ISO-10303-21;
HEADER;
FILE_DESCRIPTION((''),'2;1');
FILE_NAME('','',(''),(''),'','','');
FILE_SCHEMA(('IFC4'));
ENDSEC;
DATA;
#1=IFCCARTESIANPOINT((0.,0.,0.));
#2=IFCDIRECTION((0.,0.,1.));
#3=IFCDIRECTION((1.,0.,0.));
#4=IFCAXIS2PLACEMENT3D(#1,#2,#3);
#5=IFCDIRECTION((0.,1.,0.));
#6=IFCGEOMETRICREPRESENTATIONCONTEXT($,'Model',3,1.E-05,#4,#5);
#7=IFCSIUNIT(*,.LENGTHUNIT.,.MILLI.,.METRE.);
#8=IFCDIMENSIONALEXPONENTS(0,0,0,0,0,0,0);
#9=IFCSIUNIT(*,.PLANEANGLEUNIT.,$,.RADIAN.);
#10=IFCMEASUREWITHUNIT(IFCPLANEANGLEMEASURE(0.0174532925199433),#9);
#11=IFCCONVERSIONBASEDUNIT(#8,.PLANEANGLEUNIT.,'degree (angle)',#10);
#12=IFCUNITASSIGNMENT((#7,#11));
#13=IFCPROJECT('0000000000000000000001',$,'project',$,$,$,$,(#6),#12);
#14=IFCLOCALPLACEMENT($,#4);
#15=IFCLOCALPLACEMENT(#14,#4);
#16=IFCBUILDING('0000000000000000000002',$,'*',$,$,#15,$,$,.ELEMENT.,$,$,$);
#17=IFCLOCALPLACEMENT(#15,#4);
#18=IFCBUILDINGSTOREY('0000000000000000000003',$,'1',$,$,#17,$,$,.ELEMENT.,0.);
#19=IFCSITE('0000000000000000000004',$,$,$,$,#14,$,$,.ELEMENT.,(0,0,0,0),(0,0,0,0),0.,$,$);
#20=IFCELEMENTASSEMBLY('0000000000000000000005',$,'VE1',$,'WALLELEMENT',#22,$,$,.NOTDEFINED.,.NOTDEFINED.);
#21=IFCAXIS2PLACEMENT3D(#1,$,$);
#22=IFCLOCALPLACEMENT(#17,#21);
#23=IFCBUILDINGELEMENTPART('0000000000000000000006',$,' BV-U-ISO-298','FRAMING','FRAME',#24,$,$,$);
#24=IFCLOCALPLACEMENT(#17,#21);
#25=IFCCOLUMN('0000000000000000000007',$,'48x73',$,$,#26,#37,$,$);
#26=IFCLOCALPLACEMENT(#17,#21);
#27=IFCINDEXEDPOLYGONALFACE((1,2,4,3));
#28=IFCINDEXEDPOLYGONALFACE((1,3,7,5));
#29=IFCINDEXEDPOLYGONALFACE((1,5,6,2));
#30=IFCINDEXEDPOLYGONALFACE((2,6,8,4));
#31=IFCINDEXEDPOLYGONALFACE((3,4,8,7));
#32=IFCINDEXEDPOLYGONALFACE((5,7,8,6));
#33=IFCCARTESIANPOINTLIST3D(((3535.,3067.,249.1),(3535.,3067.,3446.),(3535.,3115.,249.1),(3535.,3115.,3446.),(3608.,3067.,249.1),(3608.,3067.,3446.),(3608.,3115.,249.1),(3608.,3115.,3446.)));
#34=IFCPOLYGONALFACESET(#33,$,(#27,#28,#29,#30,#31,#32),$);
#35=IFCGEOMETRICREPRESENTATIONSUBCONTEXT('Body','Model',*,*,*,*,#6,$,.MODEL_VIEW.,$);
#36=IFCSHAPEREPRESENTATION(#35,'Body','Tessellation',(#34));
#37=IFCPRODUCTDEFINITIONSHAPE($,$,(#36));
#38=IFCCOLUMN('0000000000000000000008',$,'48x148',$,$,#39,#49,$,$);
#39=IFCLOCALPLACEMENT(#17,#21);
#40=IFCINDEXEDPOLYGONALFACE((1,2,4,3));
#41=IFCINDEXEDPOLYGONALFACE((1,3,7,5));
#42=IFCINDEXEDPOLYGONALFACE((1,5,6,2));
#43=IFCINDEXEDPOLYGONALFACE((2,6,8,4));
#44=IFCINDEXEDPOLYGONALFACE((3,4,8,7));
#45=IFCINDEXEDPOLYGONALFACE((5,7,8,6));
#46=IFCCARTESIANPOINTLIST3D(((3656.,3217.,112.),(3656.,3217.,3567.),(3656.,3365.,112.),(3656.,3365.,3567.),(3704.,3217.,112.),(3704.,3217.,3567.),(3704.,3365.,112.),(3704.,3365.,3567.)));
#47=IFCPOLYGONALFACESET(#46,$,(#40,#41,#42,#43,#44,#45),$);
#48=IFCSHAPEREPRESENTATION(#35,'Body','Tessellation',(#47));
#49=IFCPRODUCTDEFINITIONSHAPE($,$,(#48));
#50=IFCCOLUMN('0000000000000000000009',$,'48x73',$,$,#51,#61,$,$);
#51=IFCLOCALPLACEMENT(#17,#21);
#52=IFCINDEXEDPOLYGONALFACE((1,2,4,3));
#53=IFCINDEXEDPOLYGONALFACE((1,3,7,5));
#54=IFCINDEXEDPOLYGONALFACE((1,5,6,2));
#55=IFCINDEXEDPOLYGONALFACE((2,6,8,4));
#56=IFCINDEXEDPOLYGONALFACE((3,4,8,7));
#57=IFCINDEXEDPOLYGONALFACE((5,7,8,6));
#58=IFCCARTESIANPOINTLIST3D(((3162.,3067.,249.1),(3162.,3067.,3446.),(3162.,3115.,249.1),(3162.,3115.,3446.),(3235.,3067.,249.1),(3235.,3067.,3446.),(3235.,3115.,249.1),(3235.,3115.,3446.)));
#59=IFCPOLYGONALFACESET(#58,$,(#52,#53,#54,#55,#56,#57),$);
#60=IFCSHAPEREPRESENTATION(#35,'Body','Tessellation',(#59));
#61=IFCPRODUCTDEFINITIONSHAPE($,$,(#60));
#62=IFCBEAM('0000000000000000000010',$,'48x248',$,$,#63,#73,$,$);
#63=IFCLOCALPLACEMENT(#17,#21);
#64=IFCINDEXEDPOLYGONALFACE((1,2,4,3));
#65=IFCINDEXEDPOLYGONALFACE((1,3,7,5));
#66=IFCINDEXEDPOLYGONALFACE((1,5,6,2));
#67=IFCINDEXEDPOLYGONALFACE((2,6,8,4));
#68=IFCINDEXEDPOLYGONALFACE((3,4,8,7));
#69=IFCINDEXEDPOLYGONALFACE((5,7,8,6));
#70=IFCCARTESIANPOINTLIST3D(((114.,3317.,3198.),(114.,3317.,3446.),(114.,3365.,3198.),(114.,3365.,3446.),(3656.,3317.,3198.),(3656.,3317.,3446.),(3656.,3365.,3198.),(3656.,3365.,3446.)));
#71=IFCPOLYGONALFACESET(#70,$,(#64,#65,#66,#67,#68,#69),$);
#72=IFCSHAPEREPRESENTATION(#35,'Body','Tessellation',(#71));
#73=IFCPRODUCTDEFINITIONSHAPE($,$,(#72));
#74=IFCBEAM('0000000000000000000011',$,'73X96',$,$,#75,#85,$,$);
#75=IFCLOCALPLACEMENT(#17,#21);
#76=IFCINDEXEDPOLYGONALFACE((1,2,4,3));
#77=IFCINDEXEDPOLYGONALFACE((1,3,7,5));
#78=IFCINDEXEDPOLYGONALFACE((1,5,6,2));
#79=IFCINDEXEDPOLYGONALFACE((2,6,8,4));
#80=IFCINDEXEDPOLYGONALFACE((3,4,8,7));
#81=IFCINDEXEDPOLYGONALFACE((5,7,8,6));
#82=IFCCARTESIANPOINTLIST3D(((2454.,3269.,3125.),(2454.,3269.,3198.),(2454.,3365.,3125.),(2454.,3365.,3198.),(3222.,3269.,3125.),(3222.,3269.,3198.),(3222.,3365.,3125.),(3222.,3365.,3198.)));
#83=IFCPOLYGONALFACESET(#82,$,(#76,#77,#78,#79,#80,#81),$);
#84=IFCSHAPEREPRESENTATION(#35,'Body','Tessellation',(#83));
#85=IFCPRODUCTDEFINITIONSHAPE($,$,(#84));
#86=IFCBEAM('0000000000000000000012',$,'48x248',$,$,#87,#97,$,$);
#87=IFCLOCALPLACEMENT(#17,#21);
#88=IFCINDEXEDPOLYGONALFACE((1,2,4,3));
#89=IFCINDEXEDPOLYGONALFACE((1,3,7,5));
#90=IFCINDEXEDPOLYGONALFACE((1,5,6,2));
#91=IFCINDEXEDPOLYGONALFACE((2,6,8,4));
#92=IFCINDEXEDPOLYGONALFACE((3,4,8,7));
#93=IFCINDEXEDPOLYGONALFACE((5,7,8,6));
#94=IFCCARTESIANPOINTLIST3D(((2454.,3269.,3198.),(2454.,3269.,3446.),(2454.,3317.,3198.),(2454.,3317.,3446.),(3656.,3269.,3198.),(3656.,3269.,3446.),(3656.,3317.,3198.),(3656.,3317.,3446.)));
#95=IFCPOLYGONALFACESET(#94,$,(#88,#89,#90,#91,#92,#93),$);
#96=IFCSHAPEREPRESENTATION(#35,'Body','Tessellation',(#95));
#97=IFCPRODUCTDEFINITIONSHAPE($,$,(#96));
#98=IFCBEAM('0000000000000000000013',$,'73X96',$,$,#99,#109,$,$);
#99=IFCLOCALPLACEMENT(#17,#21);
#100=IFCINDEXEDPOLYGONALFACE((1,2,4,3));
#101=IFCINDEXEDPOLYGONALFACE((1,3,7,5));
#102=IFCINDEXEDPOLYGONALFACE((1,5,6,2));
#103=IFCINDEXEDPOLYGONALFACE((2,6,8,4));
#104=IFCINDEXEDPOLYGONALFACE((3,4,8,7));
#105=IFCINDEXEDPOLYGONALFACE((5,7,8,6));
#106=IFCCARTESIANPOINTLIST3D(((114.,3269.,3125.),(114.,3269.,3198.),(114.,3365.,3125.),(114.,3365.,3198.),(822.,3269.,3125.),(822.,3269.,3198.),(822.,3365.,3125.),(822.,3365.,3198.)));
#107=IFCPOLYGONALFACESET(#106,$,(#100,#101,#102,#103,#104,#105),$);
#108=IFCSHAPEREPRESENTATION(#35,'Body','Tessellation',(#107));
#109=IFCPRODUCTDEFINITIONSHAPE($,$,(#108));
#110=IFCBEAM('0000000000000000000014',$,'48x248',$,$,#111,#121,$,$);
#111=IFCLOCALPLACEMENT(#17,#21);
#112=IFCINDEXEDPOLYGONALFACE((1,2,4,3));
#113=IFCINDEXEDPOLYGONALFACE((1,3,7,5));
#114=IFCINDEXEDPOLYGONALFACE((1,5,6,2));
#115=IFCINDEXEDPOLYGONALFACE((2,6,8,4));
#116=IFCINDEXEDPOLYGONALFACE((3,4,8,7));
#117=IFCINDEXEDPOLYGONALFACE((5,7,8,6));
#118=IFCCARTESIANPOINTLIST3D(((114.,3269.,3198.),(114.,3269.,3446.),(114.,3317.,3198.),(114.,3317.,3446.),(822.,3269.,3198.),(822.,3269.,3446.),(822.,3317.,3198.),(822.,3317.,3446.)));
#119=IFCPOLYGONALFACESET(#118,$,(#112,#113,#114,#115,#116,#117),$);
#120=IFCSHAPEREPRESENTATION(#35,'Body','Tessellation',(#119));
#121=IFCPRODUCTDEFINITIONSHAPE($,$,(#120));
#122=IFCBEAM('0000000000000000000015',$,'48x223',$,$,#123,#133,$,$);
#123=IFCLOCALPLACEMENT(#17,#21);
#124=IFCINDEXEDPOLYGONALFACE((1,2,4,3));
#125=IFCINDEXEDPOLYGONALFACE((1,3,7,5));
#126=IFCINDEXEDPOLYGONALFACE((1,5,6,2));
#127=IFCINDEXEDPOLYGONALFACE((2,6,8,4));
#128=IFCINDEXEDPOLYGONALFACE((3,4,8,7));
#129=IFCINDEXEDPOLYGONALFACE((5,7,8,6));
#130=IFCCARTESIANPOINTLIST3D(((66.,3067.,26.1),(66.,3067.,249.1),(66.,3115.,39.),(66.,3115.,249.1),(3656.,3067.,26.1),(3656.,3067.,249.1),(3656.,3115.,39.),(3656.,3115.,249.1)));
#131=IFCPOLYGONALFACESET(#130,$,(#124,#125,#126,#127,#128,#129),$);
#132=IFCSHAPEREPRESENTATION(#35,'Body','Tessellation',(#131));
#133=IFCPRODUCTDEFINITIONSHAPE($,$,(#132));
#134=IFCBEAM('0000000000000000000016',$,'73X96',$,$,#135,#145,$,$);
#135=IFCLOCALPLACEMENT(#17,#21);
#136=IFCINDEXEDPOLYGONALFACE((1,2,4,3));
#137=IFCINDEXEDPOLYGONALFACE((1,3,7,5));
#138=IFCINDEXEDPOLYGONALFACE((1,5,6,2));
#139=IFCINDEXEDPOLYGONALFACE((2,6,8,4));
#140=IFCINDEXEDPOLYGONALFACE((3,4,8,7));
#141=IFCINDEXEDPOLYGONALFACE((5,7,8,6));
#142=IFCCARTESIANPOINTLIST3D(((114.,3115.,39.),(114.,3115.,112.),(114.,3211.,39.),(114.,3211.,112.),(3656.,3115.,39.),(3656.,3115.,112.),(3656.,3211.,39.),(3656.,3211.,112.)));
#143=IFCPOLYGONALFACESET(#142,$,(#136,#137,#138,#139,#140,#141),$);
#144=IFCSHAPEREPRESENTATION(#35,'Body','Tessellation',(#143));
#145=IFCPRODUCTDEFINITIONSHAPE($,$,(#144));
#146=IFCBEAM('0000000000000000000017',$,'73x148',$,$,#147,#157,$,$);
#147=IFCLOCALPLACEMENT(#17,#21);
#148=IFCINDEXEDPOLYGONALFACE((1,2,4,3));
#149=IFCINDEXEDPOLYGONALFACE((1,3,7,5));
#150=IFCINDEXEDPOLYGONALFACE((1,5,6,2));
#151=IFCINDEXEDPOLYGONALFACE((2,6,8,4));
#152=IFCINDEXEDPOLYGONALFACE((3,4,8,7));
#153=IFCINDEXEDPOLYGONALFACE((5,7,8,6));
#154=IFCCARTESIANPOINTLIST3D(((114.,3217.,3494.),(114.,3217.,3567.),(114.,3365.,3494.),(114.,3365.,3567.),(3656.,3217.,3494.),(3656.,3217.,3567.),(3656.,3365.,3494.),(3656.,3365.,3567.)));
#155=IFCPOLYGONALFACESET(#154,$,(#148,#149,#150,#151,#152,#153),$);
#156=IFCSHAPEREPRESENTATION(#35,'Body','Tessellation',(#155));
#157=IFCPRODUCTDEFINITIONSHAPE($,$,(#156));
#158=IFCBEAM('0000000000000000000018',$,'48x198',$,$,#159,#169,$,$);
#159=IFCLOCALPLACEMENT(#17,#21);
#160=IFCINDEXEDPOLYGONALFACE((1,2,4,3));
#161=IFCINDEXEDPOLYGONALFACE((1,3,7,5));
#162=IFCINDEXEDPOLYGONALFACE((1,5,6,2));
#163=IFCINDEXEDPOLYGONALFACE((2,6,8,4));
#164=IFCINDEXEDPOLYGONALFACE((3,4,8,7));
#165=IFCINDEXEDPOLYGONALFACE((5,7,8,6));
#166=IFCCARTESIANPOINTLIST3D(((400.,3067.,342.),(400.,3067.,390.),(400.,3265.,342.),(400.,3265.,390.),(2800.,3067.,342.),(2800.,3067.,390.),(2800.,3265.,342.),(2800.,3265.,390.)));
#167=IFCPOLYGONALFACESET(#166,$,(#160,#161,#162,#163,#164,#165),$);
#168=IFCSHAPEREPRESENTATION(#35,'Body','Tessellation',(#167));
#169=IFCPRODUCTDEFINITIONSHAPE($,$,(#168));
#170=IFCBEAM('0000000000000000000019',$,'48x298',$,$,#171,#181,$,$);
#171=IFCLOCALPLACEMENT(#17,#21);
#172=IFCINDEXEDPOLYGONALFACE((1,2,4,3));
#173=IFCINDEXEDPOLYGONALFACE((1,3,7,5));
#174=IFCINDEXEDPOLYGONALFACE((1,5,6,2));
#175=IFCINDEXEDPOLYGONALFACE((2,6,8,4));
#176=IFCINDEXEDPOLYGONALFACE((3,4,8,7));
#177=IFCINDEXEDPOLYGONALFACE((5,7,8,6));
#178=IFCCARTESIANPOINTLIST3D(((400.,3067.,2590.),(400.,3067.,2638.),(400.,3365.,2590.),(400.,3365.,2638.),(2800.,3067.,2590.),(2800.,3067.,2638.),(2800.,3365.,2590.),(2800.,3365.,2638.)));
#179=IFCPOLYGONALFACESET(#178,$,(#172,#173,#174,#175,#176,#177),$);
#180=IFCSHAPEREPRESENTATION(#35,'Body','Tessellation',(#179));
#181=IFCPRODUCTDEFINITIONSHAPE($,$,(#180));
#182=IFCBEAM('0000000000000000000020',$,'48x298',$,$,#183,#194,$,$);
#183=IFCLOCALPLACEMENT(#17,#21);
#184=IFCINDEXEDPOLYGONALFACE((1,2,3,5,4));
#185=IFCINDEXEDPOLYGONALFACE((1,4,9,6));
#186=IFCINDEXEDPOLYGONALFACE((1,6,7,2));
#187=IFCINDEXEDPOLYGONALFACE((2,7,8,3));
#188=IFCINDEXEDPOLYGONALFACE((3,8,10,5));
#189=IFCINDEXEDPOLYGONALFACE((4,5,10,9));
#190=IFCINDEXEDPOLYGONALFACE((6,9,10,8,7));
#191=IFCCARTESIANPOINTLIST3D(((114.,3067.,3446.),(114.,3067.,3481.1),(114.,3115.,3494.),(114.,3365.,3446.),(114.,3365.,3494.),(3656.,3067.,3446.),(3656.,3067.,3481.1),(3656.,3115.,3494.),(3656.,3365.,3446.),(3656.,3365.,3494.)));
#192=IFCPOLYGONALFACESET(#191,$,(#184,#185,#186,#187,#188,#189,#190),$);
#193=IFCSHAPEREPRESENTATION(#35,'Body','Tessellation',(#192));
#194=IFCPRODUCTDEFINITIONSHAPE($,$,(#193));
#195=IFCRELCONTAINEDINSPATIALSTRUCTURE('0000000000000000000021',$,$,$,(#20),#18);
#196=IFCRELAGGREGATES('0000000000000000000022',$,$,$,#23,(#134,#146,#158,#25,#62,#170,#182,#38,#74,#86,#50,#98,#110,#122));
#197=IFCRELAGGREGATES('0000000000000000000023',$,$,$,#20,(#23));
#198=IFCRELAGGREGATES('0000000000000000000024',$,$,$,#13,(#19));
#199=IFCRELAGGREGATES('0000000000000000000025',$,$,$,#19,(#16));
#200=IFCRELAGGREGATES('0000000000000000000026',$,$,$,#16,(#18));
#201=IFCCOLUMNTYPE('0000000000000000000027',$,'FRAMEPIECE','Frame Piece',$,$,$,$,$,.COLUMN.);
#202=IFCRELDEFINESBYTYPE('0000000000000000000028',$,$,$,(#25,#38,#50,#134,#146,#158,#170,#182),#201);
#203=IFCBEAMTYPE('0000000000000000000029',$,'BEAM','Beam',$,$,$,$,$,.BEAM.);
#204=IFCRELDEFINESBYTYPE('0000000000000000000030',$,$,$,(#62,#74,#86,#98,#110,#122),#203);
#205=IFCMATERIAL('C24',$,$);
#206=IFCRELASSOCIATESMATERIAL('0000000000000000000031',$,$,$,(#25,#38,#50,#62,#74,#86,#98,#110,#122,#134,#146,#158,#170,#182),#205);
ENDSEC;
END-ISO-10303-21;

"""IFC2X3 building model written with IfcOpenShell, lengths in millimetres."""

from ifc_helpers import new_model, entity, si_unit, converted_unit, direction, frame, frame_2d, origin_with_axes, place, context, subcontext, project, spatial, polyline, segment, composite_curve, rectangle, outline, extrude, material, type_object, element, aggregate, save


model = new_model("IFC2X3")

# Units and contexts
model_context = context("Model", 3, precision=1e-05, world=origin_with_axes(), true_north=direction((0.0, 1.0, 0.0)))
body_context = subcontext(model_context, "Body", "Model", "MODEL_VIEW")
ifc_project = project(units=[si_unit("LENGTHUNIT", "METRE", prefix="MILLI"), converted_unit("PLANEANGLEUNIT", "degree (angle)", entity("IfcPlaneAngleMeasure", 0.0174532925199433), si_unit("PLANEANGLEUNIT", "RADIAN"), dimensions=[0, 0, 0, 0, 0, 0, 0])], contexts=[model_context])

# Site, building, storey
site_placement = place(None, origin_with_axes())
site = spatial("IfcSite", under=ifc_project, at=site_placement, CompositionType="ELEMENT", RefLatitude=(0, 0, 0, 0), RefLongitude=(0, 0, 0, 0), RefElevation=0.0)
building_placement = place(site_placement, origin_with_axes())
building = spatial("IfcBuilding", under=site, at=building_placement, Name="*", CompositionType="ELEMENT")
storey_placement = place(building_placement, origin_with_axes())
storey = spatial("IfcBuildingStorey", under=building, at=storey_placement, Name="1", CompositionType="ELEMENT", Elevation=0.0)

# Element assembly, building element part, columns, beams
assembly_placement = place(storey_placement, origin_with_axes())
assembly = element("IfcElementAssembly", 1, at=assembly_placement, inside=storey, Name="VE1", ObjectType="WALLELEMENT", AssemblyPlace="NOTDEFINED", PredefinedType="NOTDEFINED")
building_element_part_1 = element("IfcBuildingElementPart", 2, Name=" BV-U-ISO-298", Description="FRAMING", ObjectType="FRAME")
ifc_material_1 = material(Name="C24")
column_type = type_object("IfcColumnType", Name="FRAMEPIECE", Description="Frame Piece", PredefinedType="COLUMN")
column_1_placement = place(assembly_placement, frame((3571.5, 3091.0, 3446.0), z_axis=(0.0, 0.0, -1.0), x_axis=(0.0, 1.0, 0.0)))
column_1 = element("IfcColumn", 3, at=column_1_placement, type_object=column_type, material=ifc_material_1, Name="48x73", context=body_context, shape_type="SweptSolid", body=[
    extrude(rectangle(XDim=48.0, YDim=73.0, at=frame_2d((0.0, 0.0), x_axis=(-1.0, 0.0))), origin_with_axes(), (0.0, 0.0, 1.0), 3196.9),
])
column_2_placement = place(assembly_placement, frame((3680.0, 3291.0, 3567.0), z_axis=(0.0, 0.0, -1.0), x_axis=(1.0, 0.0, 0.0)))
column_2 = element("IfcColumn", 4, at=column_2_placement, type_object=column_type, material=ifc_material_1, Name="48x148", context=body_context, shape_type="SweptSolid", body=[
    extrude(rectangle(XDim=48.0, YDim=148.0, at=frame_2d((0.0, 0.0), x_axis=(-1.0, 0.0))), origin_with_axes(), (0.0, 0.0, 1.0), 3455.0),
])
column_3_placement = place(assembly_placement, frame((3198.5, 3091.0, 3446.0), z_axis=(0.0, 0.0, -1.0), x_axis=(0.0, 1.0, 0.0)))
column_3 = element("IfcColumn", 5, at=column_3_placement, type_object=column_type, material=ifc_material_1, Name="48x73", context=body_context, shape_type="SweptSolid", body=[
    extrude(rectangle(XDim=48.0, YDim=73.0, at=frame_2d((0.0, 0.0), x_axis=(-1.0, 0.0))), origin_with_axes(), (0.0, 0.0, 1.0), 3196.9),
])
beam_type = type_object("IfcBeamType", Name="BEAM", Description="Beam", PredefinedType="BEAM")
beam_1_placement = place(assembly_placement, frame((3656.0, 3341.0, 3322.0), z_axis=(-1.0, 0.0, 0.0), x_axis=(0.0, 1.0, 0.0)))
beam_1 = element("IfcBeam", 6, at=beam_1_placement, type_object=beam_type, material=ifc_material_1, Name="48x248", context=body_context, shape_type="SweptSolid", body=[
    extrude(rectangle(XDim=48.0, YDim=248.0, at=frame_2d((0.0, 0.0), x_axis=(-1.0, 0.0))), origin_with_axes(), (0.0, 0.0, 1.0), 3542.0),
])
beam_2_placement = place(assembly_placement, frame((3222.0, 3317.0, 3161.5), z_axis=(-1.0, 0.0, 0.0), x_axis=(0.0, 0.0, 1.0)))
beam_2 = element("IfcBeam", 7, at=beam_2_placement, type_object=beam_type, material=ifc_material_1, Name="73X96", context=body_context, shape_type="SweptSolid", body=[
    extrude(rectangle(XDim=73.0, YDim=96.0, at=frame_2d((0.0, 0.0), x_axis=(-1.0, 0.0))), origin_with_axes(), (0.0, 0.0, 1.0), 768.0),
])
beam_3_placement = place(assembly_placement, frame((3656.0, 3293.0, 3322.0), z_axis=(-1.0, 0.0, 0.0), x_axis=(0.0, 1.0, 0.0)))
beam_3 = element("IfcBeam", 8, at=beam_3_placement, type_object=beam_type, material=ifc_material_1, Name="48x248", context=body_context, shape_type="SweptSolid", body=[
    extrude(rectangle(XDim=48.0, YDim=248.0, at=frame_2d((0.0, 0.0), x_axis=(-1.0, 0.0))), origin_with_axes(), (0.0, 0.0, 1.0), 1202.0),
])
beam_4_placement = place(assembly_placement, frame((822.0, 3317.0, 3161.5), z_axis=(-1.0, 0.0, 0.0), x_axis=(0.0, 0.0, 1.0)))
beam_4 = element("IfcBeam", 9, at=beam_4_placement, type_object=beam_type, material=ifc_material_1, Name="73X96", context=body_context, shape_type="SweptSolid", body=[
    extrude(rectangle(XDim=73.0, YDim=96.0, at=frame_2d((0.0, 0.0), x_axis=(-1.0, 0.0))), frame((0.0, 0.0, 0.0), z_axis=(0.0, 0.0, 1.0), x_axis=(1.0, 0.0, 0.0)), (0.0, 0.0, 1.0), 708.0),
])
beam_5_placement = place(assembly_placement, frame((822.0, 3293.0, 3322.0), z_axis=(-1.0, 0.0, 0.0), x_axis=(0.0, 1.0, 0.0)))
beam_5 = element("IfcBeam", 10, at=beam_5_placement, type_object=beam_type, material=ifc_material_1, Name="48x248", context=body_context, shape_type="SweptSolid", body=[
    extrude(rectangle(XDim=48.0, YDim=248.0, at=frame_2d((0.0, 0.0), x_axis=(-1.0, 0.0))), frame((0.0, 0.0, 0.0), z_axis=(0.0, 0.0, 1.0), x_axis=(1.0, 0.0, 0.0)), (0.0, 0.0, 1.0), 708.0),
])
beam_6_placement = place(assembly_placement, frame((3656.0, 3091.0, 137.6), z_axis=(-1.0, 0.0, 0.0), x_axis=(0.0, 1.0, 0.0)))
beam_6 = element("IfcBeam", 11, at=beam_6_placement, type_object=beam_type, material=ifc_material_1, Name="48x223", context=body_context, shape_type="SweptSolid", body=[
    extrude(outline(composite_curve([segment(polyline([(24.0, 98.6), (-24.0, 111.5), (-24.0, -111.5), (24.0, -111.5), (24.0, 98.6)]), True, "CONTINUOUS")], self_intersect=False)), origin_with_axes(), (0.0, 0.0, 1.0), 3590.0),
])
beam_7_placement = place(assembly_placement, frame((3656.0, 3163.0, 75.5), z_axis=(-1.0, 0.0, 0.0), x_axis=(0.0, 0.0, -1.0)))
beam_7 = element("IfcBeam", 12, at=beam_7_placement, type_object=column_type, material=ifc_material_1, Name="73X96", context=body_context, shape_type="SweptSolid", body=[
    extrude(rectangle(XDim=73.0, YDim=96.0, at=frame_2d((0.0, 0.0), x_axis=(-1.0, 0.0))), origin_with_axes(), (0.0, 0.0, 1.0), 3542.0),
])
beam_8_placement = place(assembly_placement, frame((3656.0, 3291.0, 3530.5), z_axis=(-1.0, 0.0, 0.0), x_axis=(0.0, 0.0, -1.0)))
beam_8 = element("IfcBeam", 13, at=beam_8_placement, type_object=column_type, material=ifc_material_1, Name="73x148", context=body_context, shape_type="SweptSolid", body=[
    extrude(rectangle(XDim=73.0, YDim=148.0, at=frame_2d((0.0, 0.0), x_axis=(-1.0, 0.0))), origin_with_axes(), (0.0, 0.0, 1.0), 3542.0),
])
beam_9_placement = place(assembly_placement, frame((2800.0, 3166.0, 366.0), z_axis=(-1.0, 0.0, 0.0), x_axis=(0.0, 0.0, -1.0)))
beam_9 = element("IfcBeam", 14, at=beam_9_placement, type_object=column_type, material=ifc_material_1, Name="48x198", context=body_context, shape_type="SweptSolid", body=[
    extrude(rectangle(XDim=48.0, YDim=198.0, at=frame_2d((0.0, 0.0), x_axis=(-1.0, 0.0))), origin_with_axes(), (0.0, 0.0, 1.0), 2400.0),
])
beam_10_placement = place(assembly_placement, frame((400.0, 3216.0, 2614.0), z_axis=(1.0, 0.0, 0.0), x_axis=(0.0, 0.0, 1.0)))
beam_10 = element("IfcBeam", 15, at=beam_10_placement, type_object=column_type, material=ifc_material_1, Name="48x298", context=body_context, shape_type="SweptSolid", body=[
    extrude(rectangle(XDim=48.0, YDim=298.0, at=frame_2d((0.0, 0.0), x_axis=(-1.0, 0.0))), frame((0.0, 0.0, 0.0), z_axis=(0.0, 0.0, 1.0), x_axis=(1.0, 0.0, 0.0)), (0.0, 0.0, 1.0), 2400.0),
])
beam_11_placement = place(assembly_placement, frame((3656.0, 3216.0, 3470.0), z_axis=(-1.0, 0.0, 0.0), x_axis=(0.0, 0.0, -1.0)))
beam_11 = element("IfcBeam", 16, at=beam_11_placement, type_object=column_type, material=ifc_material_1, Name="48x298", context=body_context, shape_type="SweptSolid", body=[
    extrude(outline(composite_curve([segment(polyline([(-11.1, 149.0), (-24.0, 101.0), (-24.0, -149.0), (24.0, -149.0), (24.0, 149.0), (-11.1, 149.0)]), True, "CONTINUOUS")], self_intersect=False)), origin_with_axes(), (0.0, 0.0, 1.0), 3542.0),
])
aggregate(building_element_part_1, [beam_7, beam_8, beam_9, column_1, beam_1, beam_10, beam_11, column_2, beam_2, beam_3, column_3, beam_4, beam_5, beam_6])
aggregate(assembly, [building_element_part_1])

save(model, "model.ifc")
